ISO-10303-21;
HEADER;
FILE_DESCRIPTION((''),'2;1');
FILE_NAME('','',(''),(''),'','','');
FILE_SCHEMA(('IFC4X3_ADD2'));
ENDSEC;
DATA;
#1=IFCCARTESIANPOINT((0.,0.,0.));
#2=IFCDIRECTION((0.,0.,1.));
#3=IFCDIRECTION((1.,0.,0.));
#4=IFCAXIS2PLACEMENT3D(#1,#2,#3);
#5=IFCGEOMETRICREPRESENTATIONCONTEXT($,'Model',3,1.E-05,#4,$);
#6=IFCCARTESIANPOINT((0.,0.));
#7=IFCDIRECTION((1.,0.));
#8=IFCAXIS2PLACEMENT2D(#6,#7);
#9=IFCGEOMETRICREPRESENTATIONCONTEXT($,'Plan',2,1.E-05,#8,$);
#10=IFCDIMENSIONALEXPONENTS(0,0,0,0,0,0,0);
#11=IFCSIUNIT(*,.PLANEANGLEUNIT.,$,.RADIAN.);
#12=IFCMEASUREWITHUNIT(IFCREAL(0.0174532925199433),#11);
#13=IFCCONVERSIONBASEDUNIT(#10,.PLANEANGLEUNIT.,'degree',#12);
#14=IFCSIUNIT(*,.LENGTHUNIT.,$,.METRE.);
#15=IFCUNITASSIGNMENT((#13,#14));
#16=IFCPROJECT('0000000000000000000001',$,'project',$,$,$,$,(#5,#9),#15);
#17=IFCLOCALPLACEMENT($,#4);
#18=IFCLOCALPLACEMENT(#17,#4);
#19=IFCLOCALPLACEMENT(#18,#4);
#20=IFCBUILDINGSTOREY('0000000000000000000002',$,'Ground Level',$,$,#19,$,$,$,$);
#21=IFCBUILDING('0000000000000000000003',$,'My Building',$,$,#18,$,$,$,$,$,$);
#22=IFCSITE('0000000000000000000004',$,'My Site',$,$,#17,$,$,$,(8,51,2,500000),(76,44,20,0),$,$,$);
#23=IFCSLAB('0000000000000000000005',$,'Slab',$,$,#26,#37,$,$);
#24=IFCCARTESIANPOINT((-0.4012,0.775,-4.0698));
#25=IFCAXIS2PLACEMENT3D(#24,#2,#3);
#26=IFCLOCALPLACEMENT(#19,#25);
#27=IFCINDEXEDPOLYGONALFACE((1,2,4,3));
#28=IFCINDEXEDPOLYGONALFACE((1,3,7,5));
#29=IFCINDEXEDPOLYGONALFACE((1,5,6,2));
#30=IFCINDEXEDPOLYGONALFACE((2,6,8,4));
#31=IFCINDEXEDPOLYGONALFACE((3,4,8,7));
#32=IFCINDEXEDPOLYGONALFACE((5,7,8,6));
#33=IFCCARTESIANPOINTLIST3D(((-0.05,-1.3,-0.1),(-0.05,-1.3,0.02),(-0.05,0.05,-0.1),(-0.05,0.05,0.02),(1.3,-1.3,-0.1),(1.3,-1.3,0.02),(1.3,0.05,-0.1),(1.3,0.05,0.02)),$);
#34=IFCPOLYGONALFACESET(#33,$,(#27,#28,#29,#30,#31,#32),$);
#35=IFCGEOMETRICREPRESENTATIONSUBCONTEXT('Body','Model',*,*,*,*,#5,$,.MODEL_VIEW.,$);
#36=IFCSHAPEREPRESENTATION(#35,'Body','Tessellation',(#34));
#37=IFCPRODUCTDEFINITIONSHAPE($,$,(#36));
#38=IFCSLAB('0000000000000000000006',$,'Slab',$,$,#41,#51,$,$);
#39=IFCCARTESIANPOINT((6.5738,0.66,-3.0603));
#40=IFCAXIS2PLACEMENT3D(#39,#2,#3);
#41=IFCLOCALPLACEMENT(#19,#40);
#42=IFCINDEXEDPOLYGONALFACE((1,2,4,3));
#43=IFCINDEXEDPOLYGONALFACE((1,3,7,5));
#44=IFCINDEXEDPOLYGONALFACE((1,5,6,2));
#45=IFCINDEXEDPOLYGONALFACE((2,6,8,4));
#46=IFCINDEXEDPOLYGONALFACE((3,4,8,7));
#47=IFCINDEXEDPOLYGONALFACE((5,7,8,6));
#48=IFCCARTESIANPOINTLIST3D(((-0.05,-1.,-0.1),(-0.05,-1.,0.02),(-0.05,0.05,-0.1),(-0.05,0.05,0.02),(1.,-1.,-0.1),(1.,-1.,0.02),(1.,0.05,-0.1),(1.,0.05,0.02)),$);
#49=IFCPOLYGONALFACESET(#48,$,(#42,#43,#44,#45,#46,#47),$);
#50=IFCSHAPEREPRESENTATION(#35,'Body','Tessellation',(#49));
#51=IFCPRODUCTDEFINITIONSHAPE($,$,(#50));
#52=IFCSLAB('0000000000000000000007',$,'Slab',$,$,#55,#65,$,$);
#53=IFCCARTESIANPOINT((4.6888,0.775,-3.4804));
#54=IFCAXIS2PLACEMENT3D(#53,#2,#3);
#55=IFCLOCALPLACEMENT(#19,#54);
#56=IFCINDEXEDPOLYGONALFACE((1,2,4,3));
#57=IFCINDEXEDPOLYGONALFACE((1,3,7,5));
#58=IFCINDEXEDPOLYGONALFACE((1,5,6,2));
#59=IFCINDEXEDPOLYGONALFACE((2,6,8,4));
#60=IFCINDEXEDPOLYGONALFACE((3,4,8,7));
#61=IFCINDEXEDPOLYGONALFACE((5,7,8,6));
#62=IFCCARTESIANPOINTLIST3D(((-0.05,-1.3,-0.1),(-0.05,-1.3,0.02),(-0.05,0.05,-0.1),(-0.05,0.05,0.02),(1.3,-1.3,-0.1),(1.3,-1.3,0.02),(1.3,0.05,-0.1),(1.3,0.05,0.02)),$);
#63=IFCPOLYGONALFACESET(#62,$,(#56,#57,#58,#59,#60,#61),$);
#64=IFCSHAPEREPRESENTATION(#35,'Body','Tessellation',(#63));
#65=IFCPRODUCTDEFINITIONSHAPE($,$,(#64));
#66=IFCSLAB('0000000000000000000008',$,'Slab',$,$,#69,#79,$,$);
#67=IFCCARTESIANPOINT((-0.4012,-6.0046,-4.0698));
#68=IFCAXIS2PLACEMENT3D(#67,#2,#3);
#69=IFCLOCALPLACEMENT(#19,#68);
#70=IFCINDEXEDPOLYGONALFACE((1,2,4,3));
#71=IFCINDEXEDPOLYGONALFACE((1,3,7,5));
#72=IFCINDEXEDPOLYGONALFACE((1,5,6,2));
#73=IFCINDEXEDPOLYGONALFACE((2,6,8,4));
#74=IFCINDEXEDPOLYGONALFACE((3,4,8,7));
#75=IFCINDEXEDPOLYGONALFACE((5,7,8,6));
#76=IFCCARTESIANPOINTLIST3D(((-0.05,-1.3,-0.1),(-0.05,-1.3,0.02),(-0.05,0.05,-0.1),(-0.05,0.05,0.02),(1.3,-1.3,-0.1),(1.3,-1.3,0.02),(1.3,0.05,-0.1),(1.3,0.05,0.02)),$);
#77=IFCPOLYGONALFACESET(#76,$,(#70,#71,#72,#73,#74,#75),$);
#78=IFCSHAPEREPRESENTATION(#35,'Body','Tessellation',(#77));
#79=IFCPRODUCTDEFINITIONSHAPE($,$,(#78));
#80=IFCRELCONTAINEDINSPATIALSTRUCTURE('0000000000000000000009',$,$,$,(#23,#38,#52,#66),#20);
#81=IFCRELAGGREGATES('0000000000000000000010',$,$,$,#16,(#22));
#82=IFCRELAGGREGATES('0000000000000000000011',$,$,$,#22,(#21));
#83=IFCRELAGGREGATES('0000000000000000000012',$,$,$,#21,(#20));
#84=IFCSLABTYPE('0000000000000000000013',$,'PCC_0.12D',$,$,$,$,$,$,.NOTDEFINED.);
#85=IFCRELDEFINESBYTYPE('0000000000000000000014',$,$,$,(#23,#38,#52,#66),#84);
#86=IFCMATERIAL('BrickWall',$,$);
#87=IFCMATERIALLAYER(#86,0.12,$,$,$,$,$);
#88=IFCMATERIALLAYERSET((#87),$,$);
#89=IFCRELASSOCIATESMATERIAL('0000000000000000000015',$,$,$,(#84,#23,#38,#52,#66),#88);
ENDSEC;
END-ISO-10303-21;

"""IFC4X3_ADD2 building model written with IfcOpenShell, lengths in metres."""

from ifc_helpers import new_model, entity, si_unit, converted_unit, frame, origin_with_axes, origin_2d_with_axis, place, context, subcontext, project, spatial, indexed_curve, outline, extrude, material, layer, layer_set, layer_usage, type_object, element, save


model = new_model("IFC4X3_ADD2")

# Units and contexts
model_context = context("Model", 3, precision=1e-05, world=origin_with_axes())
plan_context = context("Plan", 2, precision=1e-05, world=origin_2d_with_axis())
body_context = subcontext(model_context, "Body", "Model", "MODEL_VIEW")
ifc_project = project(units=[converted_unit("PLANEANGLEUNIT", "degree", entity("IfcReal", 0.0174532925199433), si_unit("PLANEANGLEUNIT", "RADIAN"), dimensions=[0, 0, 0, 0, 0, 0, 0]), si_unit("LENGTHUNIT", "METRE")], contexts=[model_context, plan_context])

# Site, building, storey
site_placement = place(None, origin_with_axes())
site = spatial("IfcSite", under=ifc_project, at=site_placement, Name="My Site", RefLatitude=(8, 51, 2, 500000), RefLongitude=(76, 44, 20, 0))
building_placement = place(site_placement, origin_with_axes())
building = spatial("IfcBuilding", under=site, at=building_placement, Name="My Building")
storey_placement = place(building_placement, origin_with_axes())
storey = spatial("IfcBuildingStorey", under=building, at=storey_placement, Name="Ground Level")

# Slabs
ifc_material_1 = material(Name="BrickWall")
ifc_layer_1 = layer(ifc_material_1, 0.12)
ifc_layer_set_1 = layer_set([ifc_layer_1])
ifc_layer_usage_1 = layer_usage(ifc_layer_set_1, "AXIS3", "POSITIVE", -0.1)
slab_type = type_object("IfcSlabType", Name="PCC_0.12D", PredefinedType="NOTDEFINED", material=ifc_layer_set_1)
slab_1_placement = place(storey_placement, frame((-0.4012, 0.775, -4.0698), z_axis=(0.0, 0.0, 1.0), x_axis=(1.0, 0.0, 0.0)))
element("IfcSlab", 1, at=slab_1_placement, inside=storey, type_object=slab_type, material=ifc_layer_usage_1, Name="Slab", context=body_context, shape_type="SweptSolid", body=[
    extrude(outline(indexed_curve([(1.3, 0.05), (1.3, -1.3), (-0.05, -1.3), (-0.05, 0.05), (1.3, 0.05)])), frame((0.0, 0.0, -0.1), z_axis=(0.0, 0.0, 1.0), x_axis=(1.0, 0.0, 0.0)), (0.0, 0.0, 1.0), 0.12),
])
ifc_layer_usage_2 = layer_usage(ifc_layer_set_1, "AXIS3", "POSITIVE", -0.1)
slab_2_placement = place(storey_placement, frame((6.5738, 0.66, -3.0603), z_axis=(0.0, 0.0, 1.0), x_axis=(1.0, 0.0, 0.0)))
element("IfcSlab", 2, at=slab_2_placement, inside=storey, type_object=slab_type, material=ifc_layer_usage_2, Name="Slab", context=body_context, shape_type="SweptSolid", body=[
    extrude(outline(indexed_curve([(1.0, 0.05), (1.0, -1.0), (-0.05, -1.0), (-0.05, 0.05), (1.0, 0.05)])), frame((0.0, 0.0, -0.1), z_axis=(0.0, 0.0, 1.0), x_axis=(1.0, 0.0, 0.0)), (0.0, 0.0, 1.0), 0.12),
])
ifc_layer_usage_3 = layer_usage(ifc_layer_set_1, "AXIS3", "POSITIVE", -0.1)
slab_3_placement = place(storey_placement, frame((4.6888, 0.775, -3.4804), z_axis=(0.0, 0.0, 1.0), x_axis=(1.0, 0.0, 0.0)))
element("IfcSlab", 3, at=slab_3_placement, inside=storey, type_object=slab_type, material=ifc_layer_usage_3, Name="Slab", context=body_context, shape_type="SweptSolid", body=[
    extrude(outline(indexed_curve([(1.3, 0.05), (1.3, -1.3), (-0.05, -1.3), (-0.05, 0.05), (1.3, 0.05)])), frame((0.0, 0.0, -0.1), z_axis=(0.0, 0.0, 1.0), x_axis=(1.0, 0.0, 0.0)), (0.0, 0.0, 1.0), 0.12),
])
ifc_layer_usage_4 = layer_usage(ifc_layer_set_1, "AXIS3", "POSITIVE", -0.1)
slab_4_placement = place(storey_placement, frame((-0.4012, -6.0046, -4.0698), z_axis=(0.0, 0.0, 1.0), x_axis=(1.0, 0.0, 0.0)))
element("IfcSlab", 4, at=slab_4_placement, inside=storey, type_object=slab_type, material=ifc_layer_usage_4, Name="Slab", context=body_context, shape_type="SweptSolid", body=[
    extrude(outline(indexed_curve([(1.3, 0.05), (1.3, -1.3), (-0.05, -1.3), (-0.05, 0.05), (1.3, 0.05)])), frame((0.0, 0.0, -0.1), z_axis=(0.0, 0.0, 1.0), x_axis=(1.0, 0.0, 0.0)), (0.0, 0.0, 1.0), 0.12),
])

save(model, "model.ifc")
